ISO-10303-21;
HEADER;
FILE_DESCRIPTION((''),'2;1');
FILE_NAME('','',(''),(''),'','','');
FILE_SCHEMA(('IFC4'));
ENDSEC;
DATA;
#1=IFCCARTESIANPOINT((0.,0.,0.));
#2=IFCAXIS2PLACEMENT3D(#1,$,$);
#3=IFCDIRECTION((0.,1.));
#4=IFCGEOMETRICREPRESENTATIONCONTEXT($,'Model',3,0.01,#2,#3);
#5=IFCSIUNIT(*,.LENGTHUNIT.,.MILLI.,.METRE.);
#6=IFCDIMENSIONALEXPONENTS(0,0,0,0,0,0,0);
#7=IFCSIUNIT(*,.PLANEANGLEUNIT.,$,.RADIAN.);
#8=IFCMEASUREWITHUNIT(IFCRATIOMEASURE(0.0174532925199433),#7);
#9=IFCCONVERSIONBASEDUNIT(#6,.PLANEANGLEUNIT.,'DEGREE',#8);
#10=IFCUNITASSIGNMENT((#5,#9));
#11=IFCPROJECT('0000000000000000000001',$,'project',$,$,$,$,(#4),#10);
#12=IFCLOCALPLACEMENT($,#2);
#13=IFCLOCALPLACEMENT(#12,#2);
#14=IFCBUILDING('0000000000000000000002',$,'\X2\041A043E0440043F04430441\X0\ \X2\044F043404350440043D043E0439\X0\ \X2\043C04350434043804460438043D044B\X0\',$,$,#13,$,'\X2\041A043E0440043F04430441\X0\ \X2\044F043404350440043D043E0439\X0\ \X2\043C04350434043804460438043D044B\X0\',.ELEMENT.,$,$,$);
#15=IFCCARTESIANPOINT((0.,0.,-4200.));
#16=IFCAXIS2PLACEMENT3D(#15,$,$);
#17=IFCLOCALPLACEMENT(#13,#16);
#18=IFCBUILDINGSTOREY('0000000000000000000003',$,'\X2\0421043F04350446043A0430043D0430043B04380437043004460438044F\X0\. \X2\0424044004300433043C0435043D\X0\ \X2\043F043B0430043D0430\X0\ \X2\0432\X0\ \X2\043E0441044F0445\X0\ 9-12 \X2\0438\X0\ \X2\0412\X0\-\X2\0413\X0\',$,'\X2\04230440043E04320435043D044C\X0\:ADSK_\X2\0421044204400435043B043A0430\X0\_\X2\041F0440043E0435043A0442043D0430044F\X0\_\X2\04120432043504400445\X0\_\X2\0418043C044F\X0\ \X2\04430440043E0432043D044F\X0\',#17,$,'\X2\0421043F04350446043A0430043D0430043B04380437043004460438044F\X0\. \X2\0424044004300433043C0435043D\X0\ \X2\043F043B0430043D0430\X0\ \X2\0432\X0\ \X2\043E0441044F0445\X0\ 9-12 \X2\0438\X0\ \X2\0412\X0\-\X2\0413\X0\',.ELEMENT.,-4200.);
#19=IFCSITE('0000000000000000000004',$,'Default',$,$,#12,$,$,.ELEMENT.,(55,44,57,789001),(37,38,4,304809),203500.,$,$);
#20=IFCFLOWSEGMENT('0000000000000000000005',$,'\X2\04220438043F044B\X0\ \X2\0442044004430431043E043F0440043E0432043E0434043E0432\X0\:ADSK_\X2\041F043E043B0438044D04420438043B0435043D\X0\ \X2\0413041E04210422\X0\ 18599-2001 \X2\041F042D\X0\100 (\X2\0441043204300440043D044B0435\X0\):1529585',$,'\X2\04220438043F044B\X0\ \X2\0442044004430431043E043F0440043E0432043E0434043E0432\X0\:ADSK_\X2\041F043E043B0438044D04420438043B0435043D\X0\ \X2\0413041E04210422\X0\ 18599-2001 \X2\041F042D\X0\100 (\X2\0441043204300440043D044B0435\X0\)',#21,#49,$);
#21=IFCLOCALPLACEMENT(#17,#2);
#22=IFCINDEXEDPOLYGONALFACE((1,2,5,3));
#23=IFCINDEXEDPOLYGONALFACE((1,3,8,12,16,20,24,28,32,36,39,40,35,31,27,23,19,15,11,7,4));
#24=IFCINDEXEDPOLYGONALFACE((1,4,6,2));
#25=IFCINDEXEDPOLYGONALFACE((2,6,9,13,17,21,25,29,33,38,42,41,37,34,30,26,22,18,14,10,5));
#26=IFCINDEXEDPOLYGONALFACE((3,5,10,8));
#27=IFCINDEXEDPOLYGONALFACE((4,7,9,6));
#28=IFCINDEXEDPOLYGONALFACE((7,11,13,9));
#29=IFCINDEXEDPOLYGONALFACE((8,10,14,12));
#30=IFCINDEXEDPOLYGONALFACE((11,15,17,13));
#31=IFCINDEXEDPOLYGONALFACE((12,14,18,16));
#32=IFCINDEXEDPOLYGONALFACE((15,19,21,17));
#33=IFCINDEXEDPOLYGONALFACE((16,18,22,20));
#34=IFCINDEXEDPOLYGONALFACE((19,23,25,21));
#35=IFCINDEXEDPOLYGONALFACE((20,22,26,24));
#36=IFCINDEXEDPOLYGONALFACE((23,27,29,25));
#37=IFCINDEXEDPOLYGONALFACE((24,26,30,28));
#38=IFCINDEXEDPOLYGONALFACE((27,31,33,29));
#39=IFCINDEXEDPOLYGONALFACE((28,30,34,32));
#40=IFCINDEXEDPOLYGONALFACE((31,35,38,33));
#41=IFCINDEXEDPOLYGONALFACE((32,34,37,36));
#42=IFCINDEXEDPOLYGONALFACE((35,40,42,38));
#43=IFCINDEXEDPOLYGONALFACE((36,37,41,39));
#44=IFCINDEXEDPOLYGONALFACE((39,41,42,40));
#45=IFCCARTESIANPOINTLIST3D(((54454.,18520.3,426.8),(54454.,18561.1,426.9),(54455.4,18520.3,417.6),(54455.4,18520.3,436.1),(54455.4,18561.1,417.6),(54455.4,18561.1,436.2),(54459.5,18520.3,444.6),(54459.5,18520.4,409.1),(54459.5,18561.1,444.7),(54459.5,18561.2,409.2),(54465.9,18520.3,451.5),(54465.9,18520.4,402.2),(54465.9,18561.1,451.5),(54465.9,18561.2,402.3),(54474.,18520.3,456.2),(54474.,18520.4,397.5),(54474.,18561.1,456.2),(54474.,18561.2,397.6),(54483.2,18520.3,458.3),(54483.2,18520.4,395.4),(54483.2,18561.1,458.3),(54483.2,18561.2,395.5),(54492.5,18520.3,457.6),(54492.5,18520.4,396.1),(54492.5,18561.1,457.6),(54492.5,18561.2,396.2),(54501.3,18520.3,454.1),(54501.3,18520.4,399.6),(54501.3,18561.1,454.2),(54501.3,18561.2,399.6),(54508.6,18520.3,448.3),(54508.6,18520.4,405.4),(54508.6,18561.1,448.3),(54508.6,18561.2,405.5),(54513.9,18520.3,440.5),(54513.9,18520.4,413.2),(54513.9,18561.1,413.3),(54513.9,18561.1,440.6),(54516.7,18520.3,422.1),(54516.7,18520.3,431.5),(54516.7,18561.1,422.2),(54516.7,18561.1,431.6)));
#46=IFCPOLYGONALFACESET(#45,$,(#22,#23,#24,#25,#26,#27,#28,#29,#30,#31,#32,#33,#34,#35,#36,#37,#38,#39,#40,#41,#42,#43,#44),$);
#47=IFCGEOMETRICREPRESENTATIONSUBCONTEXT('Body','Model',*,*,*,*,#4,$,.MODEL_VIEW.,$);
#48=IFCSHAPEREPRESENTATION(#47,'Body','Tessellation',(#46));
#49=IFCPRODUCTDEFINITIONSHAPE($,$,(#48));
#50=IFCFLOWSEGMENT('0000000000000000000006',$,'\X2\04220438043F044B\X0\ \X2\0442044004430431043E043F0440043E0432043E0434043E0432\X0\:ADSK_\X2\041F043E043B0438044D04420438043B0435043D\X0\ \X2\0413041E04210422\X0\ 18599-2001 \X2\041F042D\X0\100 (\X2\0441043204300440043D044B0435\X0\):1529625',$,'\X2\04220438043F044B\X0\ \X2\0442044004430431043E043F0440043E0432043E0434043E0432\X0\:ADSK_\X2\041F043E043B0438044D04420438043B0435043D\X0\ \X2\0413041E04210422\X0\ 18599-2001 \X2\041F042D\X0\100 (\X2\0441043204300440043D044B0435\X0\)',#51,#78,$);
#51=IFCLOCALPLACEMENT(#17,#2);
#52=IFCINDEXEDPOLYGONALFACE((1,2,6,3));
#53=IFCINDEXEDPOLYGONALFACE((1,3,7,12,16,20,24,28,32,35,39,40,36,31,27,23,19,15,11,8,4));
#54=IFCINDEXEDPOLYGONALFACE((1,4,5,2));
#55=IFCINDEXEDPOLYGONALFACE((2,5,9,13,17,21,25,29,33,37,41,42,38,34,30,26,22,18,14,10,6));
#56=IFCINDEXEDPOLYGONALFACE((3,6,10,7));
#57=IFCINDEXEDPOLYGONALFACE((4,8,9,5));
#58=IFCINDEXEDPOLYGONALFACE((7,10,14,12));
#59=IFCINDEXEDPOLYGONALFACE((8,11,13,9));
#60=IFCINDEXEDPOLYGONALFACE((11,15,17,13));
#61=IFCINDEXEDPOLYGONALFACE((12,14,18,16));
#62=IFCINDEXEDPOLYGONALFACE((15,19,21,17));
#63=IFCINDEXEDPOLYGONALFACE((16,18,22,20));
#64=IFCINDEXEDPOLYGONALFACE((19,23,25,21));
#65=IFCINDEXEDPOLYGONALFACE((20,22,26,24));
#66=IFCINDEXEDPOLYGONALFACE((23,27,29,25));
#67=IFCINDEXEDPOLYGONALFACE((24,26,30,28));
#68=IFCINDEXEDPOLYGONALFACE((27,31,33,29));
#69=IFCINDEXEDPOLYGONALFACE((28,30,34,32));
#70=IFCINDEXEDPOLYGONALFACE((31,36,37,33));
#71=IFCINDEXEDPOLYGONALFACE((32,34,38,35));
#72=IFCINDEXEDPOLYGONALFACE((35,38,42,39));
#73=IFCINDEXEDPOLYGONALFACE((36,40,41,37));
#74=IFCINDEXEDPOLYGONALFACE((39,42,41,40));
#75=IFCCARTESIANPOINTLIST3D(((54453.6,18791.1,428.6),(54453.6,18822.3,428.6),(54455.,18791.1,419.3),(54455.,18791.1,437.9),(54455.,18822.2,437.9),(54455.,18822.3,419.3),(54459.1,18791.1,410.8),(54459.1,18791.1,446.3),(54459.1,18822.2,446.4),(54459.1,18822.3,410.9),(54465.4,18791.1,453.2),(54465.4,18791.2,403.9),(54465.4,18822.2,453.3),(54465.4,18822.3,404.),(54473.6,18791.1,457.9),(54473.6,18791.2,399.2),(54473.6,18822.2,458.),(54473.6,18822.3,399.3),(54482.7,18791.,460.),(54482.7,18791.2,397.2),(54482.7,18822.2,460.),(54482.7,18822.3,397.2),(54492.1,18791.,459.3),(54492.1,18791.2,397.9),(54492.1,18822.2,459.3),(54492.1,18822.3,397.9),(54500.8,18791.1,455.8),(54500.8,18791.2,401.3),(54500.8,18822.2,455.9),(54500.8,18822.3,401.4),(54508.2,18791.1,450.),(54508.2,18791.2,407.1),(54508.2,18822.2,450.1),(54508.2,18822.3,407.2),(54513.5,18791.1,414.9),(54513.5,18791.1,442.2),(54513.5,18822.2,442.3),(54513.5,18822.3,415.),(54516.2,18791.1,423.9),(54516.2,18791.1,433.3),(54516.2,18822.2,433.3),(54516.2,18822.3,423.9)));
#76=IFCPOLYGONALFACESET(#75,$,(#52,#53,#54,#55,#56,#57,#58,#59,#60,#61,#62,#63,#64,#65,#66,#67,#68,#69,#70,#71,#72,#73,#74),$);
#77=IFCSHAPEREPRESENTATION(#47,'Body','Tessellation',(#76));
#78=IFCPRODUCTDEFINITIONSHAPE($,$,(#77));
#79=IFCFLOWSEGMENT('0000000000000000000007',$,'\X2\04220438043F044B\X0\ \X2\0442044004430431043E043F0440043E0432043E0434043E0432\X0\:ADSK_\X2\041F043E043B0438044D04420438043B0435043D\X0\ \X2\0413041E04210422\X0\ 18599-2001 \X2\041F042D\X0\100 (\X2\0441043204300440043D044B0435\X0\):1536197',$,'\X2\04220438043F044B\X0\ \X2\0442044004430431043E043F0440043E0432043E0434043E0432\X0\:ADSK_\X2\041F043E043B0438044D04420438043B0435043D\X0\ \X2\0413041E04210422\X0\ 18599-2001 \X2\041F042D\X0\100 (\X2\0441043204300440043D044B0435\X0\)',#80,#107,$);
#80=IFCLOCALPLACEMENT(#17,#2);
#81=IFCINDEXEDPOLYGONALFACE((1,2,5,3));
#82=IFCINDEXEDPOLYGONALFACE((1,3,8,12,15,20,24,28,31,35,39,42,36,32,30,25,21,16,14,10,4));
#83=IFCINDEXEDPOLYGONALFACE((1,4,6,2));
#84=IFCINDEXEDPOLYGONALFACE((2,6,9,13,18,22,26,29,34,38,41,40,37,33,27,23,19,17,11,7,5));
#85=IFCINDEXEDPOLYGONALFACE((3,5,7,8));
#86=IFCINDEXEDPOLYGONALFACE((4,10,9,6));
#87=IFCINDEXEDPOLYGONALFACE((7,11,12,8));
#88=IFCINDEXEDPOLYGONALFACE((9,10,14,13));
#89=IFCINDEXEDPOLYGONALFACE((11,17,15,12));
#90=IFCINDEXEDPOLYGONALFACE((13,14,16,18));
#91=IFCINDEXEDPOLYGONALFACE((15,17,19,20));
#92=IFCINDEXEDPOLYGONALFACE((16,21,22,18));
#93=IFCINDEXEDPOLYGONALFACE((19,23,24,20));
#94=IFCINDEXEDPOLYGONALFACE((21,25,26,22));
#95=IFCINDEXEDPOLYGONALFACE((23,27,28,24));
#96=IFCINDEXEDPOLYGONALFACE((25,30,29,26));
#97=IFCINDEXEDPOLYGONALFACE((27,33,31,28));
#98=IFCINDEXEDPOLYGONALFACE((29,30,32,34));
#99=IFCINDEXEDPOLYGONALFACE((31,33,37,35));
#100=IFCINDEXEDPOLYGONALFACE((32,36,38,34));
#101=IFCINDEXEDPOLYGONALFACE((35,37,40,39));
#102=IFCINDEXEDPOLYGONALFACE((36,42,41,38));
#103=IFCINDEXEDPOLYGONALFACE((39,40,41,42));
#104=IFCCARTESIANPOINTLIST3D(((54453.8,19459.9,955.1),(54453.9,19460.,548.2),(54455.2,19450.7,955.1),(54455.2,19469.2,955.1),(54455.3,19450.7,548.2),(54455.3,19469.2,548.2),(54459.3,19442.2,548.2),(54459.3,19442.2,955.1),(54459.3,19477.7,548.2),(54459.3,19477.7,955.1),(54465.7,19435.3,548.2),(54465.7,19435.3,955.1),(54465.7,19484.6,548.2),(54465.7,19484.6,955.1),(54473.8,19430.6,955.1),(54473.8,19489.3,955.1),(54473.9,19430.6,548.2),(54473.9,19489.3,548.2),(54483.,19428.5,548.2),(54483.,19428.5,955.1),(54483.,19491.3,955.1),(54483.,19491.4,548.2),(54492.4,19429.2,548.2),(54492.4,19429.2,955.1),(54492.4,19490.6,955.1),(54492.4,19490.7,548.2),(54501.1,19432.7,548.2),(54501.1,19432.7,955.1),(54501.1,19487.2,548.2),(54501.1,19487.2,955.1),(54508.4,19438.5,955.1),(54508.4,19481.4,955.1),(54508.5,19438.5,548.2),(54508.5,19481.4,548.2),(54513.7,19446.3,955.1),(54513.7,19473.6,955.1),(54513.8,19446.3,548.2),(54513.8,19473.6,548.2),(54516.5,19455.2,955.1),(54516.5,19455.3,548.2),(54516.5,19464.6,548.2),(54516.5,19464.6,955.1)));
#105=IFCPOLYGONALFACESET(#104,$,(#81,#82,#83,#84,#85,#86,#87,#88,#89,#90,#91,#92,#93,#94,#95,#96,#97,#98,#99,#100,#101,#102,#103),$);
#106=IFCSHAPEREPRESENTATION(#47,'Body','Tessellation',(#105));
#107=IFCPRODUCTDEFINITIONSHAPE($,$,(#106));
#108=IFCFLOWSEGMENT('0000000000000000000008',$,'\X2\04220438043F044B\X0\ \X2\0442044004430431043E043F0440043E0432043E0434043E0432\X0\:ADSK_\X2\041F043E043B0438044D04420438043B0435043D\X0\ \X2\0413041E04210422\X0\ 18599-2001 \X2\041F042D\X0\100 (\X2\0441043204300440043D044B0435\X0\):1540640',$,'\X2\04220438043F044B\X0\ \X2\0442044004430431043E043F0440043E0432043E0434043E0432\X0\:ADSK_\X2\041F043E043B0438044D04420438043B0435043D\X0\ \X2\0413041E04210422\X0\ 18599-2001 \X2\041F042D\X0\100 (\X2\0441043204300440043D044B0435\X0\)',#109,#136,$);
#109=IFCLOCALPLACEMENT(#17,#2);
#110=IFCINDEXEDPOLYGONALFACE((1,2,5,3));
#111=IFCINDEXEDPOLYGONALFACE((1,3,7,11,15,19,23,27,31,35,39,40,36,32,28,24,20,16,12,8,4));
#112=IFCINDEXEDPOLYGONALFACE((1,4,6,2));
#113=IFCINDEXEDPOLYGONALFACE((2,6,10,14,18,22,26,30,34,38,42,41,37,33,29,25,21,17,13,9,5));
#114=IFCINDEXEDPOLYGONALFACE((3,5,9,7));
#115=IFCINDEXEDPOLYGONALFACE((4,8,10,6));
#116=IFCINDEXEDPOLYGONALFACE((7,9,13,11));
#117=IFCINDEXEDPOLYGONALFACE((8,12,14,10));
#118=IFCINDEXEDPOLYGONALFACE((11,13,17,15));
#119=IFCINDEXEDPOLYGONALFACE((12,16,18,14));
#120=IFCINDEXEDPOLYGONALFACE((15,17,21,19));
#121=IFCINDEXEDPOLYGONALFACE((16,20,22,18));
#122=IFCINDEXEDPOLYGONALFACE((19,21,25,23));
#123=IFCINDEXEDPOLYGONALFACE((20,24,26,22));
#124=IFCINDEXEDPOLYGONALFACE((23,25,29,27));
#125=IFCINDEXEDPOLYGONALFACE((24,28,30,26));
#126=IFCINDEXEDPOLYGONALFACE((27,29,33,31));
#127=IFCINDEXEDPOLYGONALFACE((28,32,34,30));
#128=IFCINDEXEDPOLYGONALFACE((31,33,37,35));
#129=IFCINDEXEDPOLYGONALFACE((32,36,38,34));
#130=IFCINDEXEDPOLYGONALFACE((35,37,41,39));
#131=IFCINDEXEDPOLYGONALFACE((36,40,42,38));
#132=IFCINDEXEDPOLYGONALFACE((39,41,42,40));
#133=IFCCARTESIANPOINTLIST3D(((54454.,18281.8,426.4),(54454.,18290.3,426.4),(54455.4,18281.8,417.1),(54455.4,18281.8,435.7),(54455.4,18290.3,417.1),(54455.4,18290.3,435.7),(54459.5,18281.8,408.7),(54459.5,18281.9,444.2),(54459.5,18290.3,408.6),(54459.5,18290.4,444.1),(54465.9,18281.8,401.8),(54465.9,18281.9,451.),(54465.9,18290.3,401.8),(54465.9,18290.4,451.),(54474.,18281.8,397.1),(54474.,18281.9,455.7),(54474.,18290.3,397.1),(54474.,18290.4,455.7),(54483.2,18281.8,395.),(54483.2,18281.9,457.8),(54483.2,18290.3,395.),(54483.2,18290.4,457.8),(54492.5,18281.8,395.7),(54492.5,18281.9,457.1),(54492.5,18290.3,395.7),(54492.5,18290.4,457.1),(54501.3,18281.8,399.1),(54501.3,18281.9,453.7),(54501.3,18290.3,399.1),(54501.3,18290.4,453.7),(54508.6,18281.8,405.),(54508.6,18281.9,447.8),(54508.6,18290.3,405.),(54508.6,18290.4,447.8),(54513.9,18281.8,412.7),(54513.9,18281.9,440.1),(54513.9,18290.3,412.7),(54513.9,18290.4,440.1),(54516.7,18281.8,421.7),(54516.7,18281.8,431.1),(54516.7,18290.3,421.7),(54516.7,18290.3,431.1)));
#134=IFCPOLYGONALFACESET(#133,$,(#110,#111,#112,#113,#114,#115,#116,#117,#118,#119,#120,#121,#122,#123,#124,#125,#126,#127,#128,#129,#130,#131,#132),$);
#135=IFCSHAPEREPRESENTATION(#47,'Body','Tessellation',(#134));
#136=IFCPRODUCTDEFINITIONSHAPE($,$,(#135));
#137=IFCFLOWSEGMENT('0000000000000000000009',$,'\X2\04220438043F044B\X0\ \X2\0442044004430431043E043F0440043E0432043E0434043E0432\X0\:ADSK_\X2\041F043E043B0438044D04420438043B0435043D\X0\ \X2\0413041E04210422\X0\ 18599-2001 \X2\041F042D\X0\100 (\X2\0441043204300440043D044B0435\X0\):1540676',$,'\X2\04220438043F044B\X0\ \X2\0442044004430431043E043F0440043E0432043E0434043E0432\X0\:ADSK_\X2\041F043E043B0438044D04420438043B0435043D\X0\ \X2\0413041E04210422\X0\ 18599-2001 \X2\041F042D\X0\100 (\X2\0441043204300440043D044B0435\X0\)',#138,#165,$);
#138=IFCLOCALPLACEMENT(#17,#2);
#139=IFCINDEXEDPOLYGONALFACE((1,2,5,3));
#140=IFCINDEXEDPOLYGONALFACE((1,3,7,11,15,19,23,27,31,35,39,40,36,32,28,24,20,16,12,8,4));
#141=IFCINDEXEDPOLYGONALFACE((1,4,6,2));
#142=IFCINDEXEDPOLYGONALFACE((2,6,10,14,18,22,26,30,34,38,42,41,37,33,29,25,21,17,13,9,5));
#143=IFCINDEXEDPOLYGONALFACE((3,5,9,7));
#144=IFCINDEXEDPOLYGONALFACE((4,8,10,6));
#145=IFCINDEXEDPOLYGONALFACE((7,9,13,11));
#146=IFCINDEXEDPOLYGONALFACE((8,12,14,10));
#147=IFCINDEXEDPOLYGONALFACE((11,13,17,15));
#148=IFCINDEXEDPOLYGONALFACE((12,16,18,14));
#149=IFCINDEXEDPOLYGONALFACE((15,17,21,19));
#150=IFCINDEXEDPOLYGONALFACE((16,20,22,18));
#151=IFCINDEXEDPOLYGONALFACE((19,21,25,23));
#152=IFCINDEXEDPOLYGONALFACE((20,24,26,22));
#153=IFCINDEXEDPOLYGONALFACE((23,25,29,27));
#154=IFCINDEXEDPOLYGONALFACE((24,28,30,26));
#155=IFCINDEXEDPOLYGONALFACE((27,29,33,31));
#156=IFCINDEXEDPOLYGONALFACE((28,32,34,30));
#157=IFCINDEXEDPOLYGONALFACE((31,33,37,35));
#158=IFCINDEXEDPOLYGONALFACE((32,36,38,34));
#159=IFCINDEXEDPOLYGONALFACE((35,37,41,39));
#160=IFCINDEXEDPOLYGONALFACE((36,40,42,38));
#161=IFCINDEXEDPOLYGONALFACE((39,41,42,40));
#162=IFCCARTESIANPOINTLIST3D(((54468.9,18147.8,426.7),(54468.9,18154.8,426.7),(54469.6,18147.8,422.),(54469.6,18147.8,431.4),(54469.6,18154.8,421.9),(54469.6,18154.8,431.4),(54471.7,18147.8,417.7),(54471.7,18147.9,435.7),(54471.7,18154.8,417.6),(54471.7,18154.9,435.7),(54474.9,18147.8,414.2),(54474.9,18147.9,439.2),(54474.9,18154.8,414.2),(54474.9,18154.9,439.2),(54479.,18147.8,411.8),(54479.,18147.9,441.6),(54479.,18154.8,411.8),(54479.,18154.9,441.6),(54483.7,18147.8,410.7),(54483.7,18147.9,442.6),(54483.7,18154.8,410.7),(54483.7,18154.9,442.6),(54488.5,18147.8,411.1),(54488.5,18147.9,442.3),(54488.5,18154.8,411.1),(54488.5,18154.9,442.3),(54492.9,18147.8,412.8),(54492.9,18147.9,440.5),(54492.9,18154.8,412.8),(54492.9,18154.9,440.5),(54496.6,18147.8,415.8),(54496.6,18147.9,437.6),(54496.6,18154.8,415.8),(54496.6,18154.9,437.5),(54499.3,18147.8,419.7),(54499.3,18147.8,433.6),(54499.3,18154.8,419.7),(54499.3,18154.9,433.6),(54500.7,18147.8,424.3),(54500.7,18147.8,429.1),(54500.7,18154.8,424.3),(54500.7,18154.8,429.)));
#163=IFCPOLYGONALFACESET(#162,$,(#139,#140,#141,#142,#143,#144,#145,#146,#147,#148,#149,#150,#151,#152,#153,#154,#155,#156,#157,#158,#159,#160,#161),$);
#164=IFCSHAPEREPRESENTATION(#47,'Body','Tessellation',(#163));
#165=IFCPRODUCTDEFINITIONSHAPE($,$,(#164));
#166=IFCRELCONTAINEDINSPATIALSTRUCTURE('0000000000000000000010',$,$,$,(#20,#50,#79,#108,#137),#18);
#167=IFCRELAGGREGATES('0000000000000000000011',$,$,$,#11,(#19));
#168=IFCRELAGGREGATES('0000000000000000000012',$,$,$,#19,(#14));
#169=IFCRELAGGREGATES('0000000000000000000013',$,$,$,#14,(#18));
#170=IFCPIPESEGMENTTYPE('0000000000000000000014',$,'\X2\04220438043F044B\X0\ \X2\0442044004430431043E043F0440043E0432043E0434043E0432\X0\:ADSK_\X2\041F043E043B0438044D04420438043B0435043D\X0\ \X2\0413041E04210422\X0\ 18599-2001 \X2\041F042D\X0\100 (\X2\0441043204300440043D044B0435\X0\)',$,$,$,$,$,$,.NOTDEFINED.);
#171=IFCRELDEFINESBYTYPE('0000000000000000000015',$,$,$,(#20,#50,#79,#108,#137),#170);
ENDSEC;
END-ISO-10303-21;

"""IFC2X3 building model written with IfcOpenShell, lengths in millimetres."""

from ifc_helpers import new_model, entity, si_unit, converted_unit, direction, frame, origin, origin_2d_with_axis, place, context, subcontext, project, spatial, circle, extrude, type_object, element, save


model = new_model("IFC2X3")

# Units and contexts
model_context = context("Model", 3, precision=0.01, world=origin(), true_north=direction((0.0, 1.0)))
body_context = subcontext(model_context, "Body", "Model", "MODEL_VIEW")
ifc_project = project(units=[si_unit("LENGTHUNIT", "METRE", prefix="MILLI"), converted_unit("PLANEANGLEUNIT", "DEGREE", entity("IfcRatioMeasure", 0.0174532925199433), si_unit("PLANEANGLEUNIT", "RADIAN"), dimensions=[0, 0, 0, 0, 0, 0, 0])], contexts=[model_context])

# Site, building, storey
site_placement = place(None, origin())
site = spatial("IfcSite", under=ifc_project, at=site_placement, Name="Default", CompositionType="ELEMENT", RefLatitude=(55, 44, 57, 789001), RefLongitude=(37, 38, 4, 304809), RefElevation=203500.0)
building_placement = place(site_placement, origin())
building = spatial("IfcBuilding", under=site, at=building_placement, Name="Корпус ядерной медицины", LongName="Корпус ядерной медицины", CompositionType="ELEMENT")
storey_placement = place(building_placement, frame((0.0, 0.0, -4200.0)))
storey = spatial("IfcBuildingStorey", under=building, at=storey_placement, Name="Спецканализация. Фрагмен плана в осях 9-12 и В-Г", ObjectType="Уровень:ADSK_Стрелка_Проектная_Вверх_Имя уровня", LongName="Спецканализация. Фрагмен плана в осях 9-12 и В-Г", CompositionType="ELEMENT", Elevation=-4200.0)

# Flow segments
pipe_segment_type = type_object("IfcPipeSegmentType", Name="Типы трубопроводов:ADSK_Полиэтилен ГОСТ 18599-2001 ПЭ100 (сварные)", PredefinedType="NOTDEFINED")
flow_segment_1_placement = place(storey_placement, frame((54452.4, 18520.3, 393.7)))
element("IfcFlowSegment", 1, at=flow_segment_1_placement, inside=storey, type_object=pipe_segment_type, Name="Типы трубопроводов:ADSK_Полиэтилен ГОСТ 18599-2001 ПЭ100 (сварные):1529585", ObjectType="Типы трубопроводов:ADSK_Полиэтилен ГОСТ 18599-2001 ПЭ100 (сварные)", context=body_context, shape_type="SweptSolid", body=[
    extrude(circle(Radius=31.5, at=origin_2d_with_axis()), frame((33.1, 0.1, 33.1), z_axis=(0.0, 0.999998, 0.001978), x_axis=(-1.0, 0.0, 0.0)), (0.0, 0.0, 1.0), 40.8),
])
flow_segment_2_placement = place(storey_placement, frame((54452.0, 18791.0, 395.5)))
element("IfcFlowSegment", 2, at=flow_segment_2_placement, inside=storey, type_object=pipe_segment_type, Name="Типы трубопроводов:ADSK_Полиэтилен ГОСТ 18599-2001 ПЭ100 (сварные):1529625", ObjectType="Типы трубопроводов:ADSK_Полиэтилен ГОСТ 18599-2001 ПЭ100 (сварные)", context=body_context, shape_type="SweptSolid", body=[
    extrude(circle(Radius=31.5, at=origin_2d_with_axis()), frame((33.1, 0.1, 33.1), z_axis=(0.0, 0.999998, 0.001978), x_axis=(-1.0, 0.0, 0.0)), (0.0, 0.0, 1.0), 31.1),
])
flow_segment_3_placement = place(storey_placement, frame((54452.2, 19426.8, 548.2)))
element("IfcFlowSegment", 3, at=flow_segment_3_placement, inside=storey, type_object=pipe_segment_type, Name="Типы трубопроводов:ADSK_Полиэтилен ГОСТ 18599-2001 ПЭ100 (сварные):1536197", ObjectType="Типы трубопроводов:ADSK_Полиэтилен ГОСТ 18599-2001 ПЭ100 (сварные)", context=body_context, shape_type="SweptSolid", body=[
    extrude(circle(Radius=31.5, at=origin_2d_with_axis()), frame((33.1, 33.1, 0.0), z_axis=(-0.000061, -0.000031, 1.0), x_axis=(-1.0, 0.0, -0.000061)), (0.0, 0.0, 1.0), 406.9),
])
flow_segment_4_placement = place(storey_placement, frame((54452.4, 18281.8, 393.3)))
element("IfcFlowSegment", 4, at=flow_segment_4_placement, inside=storey, type_object=pipe_segment_type, Name="Типы трубопроводов:ADSK_Полиэтилен ГОСТ 18599-2001 ПЭ100 (сварные):1540640", ObjectType="Типы трубопроводов:ADSK_Полиэтилен ГОСТ 18599-2001 ПЭ100 (сварные)", context=body_context, shape_type="SweptSolid", body=[
    extrude(circle(Radius=31.5, at=origin_2d_with_axis()), frame((33.1, 8.6, 33.1), z_axis=(0.0, -0.999998, 0.002), x_axis=(-1.0, 0.0, 0.0)), (0.0, 0.0, 1.0), 8.5),
])
flow_segment_5_placement = place(storey_placement, frame((54467.3, 18147.8, 409.1)))
element("IfcFlowSegment", 5, at=flow_segment_5_placement, inside=storey, type_object=pipe_segment_type, Name="Типы трубопроводов:ADSK_Полиэтилен ГОСТ 18599-2001 ПЭ100 (сварные):1540676", ObjectType="Типы трубопроводов:ADSK_Полиэтилен ГОСТ 18599-2001 ПЭ100 (сварные)", context=body_context, shape_type="SweptSolid", body=[
    extrude(circle(Radius=16.0, at=origin_2d_with_axis()), frame((17.6, 7.0, 17.6), z_axis=(0.0, -0.999998, 0.002), x_axis=(-1.0, 0.0, 0.0)), (0.0, 0.0, 1.0), 7.0),
])

save(model, "model.ifc")
